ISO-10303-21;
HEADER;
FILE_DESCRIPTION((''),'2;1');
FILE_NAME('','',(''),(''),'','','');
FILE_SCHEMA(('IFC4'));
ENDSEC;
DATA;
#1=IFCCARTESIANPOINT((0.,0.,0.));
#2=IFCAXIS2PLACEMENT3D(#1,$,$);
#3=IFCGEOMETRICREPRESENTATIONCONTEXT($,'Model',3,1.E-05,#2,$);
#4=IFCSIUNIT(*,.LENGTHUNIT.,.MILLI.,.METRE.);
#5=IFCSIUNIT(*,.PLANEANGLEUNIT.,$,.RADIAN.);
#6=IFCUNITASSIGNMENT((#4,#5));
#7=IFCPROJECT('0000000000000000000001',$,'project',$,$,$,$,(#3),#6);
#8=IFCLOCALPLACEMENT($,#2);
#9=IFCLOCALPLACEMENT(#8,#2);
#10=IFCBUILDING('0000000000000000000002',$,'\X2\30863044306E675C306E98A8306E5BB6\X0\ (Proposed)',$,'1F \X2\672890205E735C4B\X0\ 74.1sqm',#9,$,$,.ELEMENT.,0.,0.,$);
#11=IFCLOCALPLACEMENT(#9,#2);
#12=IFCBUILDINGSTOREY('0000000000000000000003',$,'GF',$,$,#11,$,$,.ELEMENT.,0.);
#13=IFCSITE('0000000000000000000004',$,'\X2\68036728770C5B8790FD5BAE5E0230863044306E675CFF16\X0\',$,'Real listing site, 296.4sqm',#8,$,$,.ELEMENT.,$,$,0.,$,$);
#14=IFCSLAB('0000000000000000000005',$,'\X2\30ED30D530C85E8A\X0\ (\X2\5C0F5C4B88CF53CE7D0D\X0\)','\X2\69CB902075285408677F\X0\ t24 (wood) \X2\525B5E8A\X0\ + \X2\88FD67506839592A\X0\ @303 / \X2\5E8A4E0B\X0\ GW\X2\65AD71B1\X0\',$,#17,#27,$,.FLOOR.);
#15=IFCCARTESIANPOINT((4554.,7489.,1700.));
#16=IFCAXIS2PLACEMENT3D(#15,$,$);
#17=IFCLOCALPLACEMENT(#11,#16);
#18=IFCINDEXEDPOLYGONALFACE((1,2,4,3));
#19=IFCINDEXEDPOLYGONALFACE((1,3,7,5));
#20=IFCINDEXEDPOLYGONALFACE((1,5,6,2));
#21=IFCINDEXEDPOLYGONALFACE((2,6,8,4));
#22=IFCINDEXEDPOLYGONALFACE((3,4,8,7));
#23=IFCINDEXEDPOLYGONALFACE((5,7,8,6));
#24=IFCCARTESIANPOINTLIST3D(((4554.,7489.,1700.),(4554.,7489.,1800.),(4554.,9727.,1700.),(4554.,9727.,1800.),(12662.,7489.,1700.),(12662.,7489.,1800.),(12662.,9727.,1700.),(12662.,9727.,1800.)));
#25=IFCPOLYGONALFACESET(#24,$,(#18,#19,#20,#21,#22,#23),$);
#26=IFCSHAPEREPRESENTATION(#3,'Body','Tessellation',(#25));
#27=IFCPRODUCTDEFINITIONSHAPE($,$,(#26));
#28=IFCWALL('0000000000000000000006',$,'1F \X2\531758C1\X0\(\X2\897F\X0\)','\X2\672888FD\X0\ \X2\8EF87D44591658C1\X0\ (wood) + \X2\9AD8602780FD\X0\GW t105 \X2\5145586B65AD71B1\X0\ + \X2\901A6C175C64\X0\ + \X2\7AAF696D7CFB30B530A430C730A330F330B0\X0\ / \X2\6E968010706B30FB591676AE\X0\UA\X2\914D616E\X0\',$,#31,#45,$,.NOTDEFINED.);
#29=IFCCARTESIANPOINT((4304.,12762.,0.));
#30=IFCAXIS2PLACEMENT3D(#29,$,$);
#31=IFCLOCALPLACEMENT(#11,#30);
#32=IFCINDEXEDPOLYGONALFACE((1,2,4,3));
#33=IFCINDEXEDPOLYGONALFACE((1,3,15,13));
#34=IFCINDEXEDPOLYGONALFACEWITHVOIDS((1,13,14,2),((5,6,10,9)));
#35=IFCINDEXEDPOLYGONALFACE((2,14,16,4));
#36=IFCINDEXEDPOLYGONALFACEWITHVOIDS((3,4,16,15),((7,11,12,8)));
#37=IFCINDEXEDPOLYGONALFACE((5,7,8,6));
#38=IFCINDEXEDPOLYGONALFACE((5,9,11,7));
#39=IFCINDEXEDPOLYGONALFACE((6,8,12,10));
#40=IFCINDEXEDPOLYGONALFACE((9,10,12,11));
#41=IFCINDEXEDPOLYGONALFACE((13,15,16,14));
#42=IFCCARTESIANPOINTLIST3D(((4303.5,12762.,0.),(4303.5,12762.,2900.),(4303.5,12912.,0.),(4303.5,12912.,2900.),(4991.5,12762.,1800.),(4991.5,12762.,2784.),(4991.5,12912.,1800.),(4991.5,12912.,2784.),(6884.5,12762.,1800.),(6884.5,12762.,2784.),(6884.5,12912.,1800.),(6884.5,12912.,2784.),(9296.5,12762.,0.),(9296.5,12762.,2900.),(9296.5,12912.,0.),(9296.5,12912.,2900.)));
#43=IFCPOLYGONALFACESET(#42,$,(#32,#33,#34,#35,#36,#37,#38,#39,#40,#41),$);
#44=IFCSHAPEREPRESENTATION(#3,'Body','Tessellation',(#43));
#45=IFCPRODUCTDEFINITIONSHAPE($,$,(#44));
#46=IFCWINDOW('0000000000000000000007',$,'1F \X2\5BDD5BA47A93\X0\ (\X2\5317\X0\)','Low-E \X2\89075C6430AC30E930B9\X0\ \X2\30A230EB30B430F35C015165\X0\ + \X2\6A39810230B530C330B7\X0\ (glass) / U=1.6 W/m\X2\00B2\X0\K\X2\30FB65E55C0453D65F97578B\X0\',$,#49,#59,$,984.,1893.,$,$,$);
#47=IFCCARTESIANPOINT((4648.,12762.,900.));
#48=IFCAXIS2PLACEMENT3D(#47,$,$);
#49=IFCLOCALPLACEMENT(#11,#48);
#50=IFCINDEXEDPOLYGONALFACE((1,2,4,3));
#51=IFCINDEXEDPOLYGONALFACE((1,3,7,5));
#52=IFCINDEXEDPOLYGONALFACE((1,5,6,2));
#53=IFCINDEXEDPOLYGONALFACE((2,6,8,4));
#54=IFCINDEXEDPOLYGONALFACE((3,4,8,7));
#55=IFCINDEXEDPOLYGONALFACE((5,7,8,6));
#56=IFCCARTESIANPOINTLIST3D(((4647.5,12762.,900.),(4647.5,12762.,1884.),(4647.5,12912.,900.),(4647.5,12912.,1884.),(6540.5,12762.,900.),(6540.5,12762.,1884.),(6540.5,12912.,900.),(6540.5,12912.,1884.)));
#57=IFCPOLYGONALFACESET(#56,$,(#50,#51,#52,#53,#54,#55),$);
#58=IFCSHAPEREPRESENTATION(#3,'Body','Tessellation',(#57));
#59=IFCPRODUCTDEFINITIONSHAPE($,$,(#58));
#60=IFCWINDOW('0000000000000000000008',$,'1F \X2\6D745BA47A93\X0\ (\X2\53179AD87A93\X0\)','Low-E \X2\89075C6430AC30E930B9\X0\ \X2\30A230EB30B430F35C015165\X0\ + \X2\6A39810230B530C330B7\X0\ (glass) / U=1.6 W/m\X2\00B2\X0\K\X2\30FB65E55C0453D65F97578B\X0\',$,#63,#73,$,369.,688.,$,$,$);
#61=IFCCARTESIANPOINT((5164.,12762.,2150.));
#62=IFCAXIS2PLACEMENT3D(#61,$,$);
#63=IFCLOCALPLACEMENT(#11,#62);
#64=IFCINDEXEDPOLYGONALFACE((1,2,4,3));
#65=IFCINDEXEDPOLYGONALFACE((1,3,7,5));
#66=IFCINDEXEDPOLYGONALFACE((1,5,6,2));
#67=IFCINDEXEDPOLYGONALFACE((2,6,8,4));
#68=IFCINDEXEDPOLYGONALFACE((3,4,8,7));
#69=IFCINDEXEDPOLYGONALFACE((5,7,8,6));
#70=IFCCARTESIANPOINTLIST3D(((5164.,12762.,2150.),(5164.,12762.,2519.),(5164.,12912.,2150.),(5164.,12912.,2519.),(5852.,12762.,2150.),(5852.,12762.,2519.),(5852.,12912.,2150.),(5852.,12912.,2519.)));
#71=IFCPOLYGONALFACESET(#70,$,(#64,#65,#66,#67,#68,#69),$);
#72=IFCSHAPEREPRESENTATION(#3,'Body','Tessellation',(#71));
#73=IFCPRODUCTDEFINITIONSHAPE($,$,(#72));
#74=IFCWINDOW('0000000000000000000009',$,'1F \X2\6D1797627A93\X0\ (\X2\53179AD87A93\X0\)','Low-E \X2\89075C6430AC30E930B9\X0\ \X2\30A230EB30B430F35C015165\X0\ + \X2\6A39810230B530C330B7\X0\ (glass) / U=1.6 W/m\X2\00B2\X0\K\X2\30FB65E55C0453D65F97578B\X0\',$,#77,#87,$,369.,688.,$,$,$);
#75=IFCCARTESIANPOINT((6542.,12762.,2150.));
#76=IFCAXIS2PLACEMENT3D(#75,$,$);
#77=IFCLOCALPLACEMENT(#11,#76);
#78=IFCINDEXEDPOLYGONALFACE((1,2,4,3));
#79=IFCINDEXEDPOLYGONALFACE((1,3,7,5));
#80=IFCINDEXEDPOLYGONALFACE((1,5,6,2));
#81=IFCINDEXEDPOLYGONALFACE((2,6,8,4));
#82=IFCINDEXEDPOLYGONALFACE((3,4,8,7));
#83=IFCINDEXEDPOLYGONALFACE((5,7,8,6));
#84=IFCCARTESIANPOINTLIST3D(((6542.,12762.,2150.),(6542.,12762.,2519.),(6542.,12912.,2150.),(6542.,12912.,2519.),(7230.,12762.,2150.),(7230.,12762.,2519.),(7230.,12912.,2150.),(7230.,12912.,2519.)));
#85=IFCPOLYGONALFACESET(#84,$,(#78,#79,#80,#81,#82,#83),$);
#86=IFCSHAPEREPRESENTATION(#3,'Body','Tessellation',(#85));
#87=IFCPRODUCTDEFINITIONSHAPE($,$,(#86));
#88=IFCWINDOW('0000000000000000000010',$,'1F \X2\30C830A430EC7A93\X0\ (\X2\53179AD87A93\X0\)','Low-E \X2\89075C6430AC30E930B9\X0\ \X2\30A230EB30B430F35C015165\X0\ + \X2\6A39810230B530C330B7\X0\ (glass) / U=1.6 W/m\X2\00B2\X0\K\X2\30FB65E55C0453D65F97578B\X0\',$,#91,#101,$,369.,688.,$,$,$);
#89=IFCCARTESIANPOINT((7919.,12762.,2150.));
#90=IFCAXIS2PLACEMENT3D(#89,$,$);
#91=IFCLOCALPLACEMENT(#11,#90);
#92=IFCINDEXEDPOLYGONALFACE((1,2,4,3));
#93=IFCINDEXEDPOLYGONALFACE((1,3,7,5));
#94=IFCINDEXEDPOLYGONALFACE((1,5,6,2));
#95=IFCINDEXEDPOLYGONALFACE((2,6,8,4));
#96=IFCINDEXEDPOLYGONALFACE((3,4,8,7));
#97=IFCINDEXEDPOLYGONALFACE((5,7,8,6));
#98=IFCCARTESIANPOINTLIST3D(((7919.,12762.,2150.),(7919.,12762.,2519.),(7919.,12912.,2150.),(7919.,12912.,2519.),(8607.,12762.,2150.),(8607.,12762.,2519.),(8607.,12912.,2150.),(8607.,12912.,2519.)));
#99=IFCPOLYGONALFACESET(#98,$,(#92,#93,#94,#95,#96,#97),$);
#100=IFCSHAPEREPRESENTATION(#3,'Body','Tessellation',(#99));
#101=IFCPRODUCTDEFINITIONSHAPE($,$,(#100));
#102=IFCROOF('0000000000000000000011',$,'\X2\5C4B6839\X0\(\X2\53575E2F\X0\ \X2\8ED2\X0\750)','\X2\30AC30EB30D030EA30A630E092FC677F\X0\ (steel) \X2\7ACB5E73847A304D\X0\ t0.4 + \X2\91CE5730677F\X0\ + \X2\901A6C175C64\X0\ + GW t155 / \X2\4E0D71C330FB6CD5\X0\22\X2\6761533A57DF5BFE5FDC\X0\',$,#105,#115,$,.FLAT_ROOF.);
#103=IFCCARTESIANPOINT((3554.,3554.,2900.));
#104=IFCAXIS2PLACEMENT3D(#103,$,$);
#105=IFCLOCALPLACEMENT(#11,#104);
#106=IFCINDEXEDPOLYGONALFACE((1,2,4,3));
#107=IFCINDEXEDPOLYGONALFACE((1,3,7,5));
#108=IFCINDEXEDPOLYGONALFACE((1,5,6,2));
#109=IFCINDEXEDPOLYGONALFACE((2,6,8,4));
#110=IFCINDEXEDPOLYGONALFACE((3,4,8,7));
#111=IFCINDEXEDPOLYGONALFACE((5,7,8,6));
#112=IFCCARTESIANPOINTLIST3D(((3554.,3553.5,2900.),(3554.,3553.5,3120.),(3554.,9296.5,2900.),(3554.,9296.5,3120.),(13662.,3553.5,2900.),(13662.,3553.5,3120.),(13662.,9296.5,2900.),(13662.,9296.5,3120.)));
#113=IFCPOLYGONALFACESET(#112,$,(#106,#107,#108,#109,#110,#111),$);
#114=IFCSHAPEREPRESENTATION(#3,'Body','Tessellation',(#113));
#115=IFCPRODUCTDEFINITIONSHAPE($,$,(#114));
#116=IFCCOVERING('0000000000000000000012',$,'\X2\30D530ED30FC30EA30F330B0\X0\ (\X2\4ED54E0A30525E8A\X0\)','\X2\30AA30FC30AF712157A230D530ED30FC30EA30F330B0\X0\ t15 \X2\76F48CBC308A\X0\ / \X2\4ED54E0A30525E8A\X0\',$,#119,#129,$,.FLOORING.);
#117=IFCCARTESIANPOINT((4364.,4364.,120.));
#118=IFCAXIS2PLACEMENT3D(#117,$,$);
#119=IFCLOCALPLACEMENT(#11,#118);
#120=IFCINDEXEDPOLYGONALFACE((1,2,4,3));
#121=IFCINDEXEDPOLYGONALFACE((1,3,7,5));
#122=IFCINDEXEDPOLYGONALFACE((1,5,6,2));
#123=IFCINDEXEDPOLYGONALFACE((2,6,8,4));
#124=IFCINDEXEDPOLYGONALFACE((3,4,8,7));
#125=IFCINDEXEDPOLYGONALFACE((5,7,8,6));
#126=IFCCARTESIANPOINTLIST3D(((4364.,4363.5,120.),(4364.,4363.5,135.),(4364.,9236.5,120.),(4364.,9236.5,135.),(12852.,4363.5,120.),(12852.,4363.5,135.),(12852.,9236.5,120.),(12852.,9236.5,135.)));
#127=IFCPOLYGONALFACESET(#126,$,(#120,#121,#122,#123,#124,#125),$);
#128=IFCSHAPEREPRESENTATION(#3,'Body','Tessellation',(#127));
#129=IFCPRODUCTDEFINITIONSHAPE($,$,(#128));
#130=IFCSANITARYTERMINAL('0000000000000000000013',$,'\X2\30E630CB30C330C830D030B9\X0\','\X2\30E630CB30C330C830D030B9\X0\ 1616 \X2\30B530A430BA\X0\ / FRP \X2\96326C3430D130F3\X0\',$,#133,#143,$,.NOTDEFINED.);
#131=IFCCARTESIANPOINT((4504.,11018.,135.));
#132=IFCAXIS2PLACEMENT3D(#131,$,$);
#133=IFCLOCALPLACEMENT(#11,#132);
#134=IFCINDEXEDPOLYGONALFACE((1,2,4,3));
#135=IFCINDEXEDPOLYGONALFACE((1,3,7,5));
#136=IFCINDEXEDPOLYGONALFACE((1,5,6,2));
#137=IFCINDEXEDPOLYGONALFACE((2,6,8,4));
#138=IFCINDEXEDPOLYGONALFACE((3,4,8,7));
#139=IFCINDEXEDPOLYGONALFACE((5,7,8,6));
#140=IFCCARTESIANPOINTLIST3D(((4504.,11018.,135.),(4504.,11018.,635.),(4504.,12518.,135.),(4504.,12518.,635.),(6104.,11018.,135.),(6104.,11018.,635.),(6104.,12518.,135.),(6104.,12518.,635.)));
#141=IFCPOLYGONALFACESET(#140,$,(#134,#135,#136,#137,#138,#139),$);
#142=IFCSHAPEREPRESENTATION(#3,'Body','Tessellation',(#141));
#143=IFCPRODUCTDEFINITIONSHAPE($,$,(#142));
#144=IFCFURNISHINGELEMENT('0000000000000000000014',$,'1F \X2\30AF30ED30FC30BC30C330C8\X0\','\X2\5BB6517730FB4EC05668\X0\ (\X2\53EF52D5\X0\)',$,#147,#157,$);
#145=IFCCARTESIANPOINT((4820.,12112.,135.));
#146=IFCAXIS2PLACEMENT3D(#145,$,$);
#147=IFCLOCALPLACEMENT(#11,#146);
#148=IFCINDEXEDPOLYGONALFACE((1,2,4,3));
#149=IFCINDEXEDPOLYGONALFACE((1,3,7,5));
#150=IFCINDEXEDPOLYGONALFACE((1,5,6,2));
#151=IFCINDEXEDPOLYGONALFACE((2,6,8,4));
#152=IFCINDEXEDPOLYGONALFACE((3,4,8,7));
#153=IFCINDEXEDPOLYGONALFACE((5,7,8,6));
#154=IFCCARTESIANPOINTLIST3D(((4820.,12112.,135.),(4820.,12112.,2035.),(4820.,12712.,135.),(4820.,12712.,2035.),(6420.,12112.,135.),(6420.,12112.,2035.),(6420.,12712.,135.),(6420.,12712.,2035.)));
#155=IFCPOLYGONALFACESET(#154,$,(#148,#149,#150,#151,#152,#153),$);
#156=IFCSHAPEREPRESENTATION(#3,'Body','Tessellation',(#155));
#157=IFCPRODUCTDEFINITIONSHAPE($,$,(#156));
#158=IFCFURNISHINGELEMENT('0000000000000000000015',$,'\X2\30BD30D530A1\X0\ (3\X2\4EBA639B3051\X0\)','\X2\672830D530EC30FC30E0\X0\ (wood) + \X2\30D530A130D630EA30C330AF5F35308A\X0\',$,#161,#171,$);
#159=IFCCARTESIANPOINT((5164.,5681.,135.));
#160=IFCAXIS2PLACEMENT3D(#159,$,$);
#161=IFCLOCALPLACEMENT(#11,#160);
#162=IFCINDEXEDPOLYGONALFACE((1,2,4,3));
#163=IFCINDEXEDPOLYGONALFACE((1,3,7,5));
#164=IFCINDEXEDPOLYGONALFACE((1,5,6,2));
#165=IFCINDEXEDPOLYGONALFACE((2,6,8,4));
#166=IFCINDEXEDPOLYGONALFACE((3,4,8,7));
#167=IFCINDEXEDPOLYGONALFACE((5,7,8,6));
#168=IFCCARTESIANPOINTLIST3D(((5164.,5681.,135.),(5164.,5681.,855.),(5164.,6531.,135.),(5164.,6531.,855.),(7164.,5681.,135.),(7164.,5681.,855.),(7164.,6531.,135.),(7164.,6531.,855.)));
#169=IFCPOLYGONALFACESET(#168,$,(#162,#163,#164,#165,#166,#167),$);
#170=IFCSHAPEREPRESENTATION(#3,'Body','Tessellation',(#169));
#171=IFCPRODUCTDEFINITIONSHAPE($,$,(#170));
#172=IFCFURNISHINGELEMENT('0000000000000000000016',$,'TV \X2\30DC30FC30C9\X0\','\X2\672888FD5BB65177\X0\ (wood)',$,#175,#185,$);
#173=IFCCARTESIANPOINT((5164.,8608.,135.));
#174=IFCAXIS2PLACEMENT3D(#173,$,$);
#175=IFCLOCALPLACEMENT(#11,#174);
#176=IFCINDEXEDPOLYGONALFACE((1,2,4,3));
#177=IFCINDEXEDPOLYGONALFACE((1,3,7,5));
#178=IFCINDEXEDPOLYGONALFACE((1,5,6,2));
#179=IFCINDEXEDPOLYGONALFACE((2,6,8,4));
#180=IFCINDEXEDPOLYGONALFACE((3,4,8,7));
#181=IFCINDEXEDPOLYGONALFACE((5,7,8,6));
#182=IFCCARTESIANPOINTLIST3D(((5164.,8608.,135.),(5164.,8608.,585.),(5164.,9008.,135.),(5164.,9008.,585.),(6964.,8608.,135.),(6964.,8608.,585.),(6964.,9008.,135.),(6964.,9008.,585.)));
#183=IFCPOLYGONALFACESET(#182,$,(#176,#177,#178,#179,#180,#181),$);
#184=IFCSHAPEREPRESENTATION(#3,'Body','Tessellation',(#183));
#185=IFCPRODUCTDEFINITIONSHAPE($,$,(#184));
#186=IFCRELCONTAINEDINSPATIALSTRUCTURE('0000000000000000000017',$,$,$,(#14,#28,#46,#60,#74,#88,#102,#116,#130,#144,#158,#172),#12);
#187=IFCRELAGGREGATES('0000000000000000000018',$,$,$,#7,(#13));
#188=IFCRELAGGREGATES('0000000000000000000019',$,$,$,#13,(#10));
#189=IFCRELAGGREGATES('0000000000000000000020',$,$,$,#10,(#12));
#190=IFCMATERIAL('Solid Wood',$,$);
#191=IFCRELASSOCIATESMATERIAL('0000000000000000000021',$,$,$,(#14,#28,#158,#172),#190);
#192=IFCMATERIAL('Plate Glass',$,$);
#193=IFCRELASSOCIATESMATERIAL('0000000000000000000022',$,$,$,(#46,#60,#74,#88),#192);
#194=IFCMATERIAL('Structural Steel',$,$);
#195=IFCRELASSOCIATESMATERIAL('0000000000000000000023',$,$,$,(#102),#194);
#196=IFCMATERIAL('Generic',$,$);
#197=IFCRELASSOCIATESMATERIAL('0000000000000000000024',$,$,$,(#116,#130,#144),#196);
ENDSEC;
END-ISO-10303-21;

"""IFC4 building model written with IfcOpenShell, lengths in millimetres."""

from ifc_helpers import new_model, si_unit, frame, frame_2d, origin, place, context, project, spatial, rectangle, extrude, material, element, fill, save


model = new_model("IFC4")

# Units and contexts
model_context = context("Model", 3, precision=1e-05, world=origin())
ifc_project = project(units=[si_unit("LENGTHUNIT", "METRE", prefix="MILLI"), si_unit("PLANEANGLEUNIT", "RADIAN")], contexts=[model_context])

# Site, building, storey
site_placement = place(None, origin())
site = spatial("IfcSite", under=ifc_project, at=site_placement, Name="栃木県宇都宮市ゆいの杜６", ObjectType="Real listing site, 296.4sqm", CompositionType="ELEMENT", RefElevation=0.0)
building_placement = place(site_placement, origin())
building = spatial("IfcBuilding", under=site, at=building_placement, Name="ゆいの杜の風の家 (Proposed)", ObjectType="1F 木造平屋 74.1sqm", CompositionType="ELEMENT", ElevationOfRefHeight=0.0, ElevationOfTerrain=0.0)
storey_placement = place(building_placement, origin())
storey = spatial("IfcBuildingStorey", under=building, at=storey_placement, Name="GF", CompositionType="ELEMENT", Elevation=0.0)

# Slab
ifc_material_1 = material(Name="Solid Wood")
slab_1_placement = place(storey_placement, frame((4554.0, 7489.0, 1700.0)))
element("IfcSlab", 1, at=slab_1_placement, inside=storey, material=ifc_material_1, Name="ロフト床 (小屋裏収納)", Description="構造用合板 t24 (wood) 剛床 + 製材根太 @303 / 床下 GW断熱", PredefinedType="FLOOR", context=model_context, shape_type="SweptSolid", body=[
    extrude(rectangle(XDim=8108.0, YDim=2238.0, at=frame_2d((4054.0, 1119.0))), frame((4554.0, 7489.0, 1700.0)), (0.0, 0.0, 1.0), 100.0),
])

# Shared definitions
ifc_material_2 = material(Name="Plate Glass")

# Wall, openings, windows
wall_1_placement = place(storey_placement, frame((4304.0, 12762.0, 0.0)))
wall_1 = element("IfcWall", 2, at=wall_1_placement, inside=storey, material=ifc_material_1, Name="1F 北壁(西)", Description="木製 軸組外壁 (wood) + 高性能GW t105 充填断熱 + 通気層 + 窯業系サイディング / 準耐火・外皮UA配慮", PredefinedType="NOTDEFINED", context=model_context, shape_type="SweptSolid", body=[
    extrude(rectangle(XDim=4993.0, YDim=150.0, at=frame_2d((2496.0, 75.0))), frame((4304.0, 12762.0, 0.0)), (0.0, 0.0, 1.0), 2900.0),
])
opening_1_placement = place(storey_placement, frame((4648.0, 12762.0, 900.0)))
opening_1 = element("IfcOpeningElement", 3, at=opening_1_placement, cuts=wall_1, PredefinedType="NOTDEFINED", context=model_context, shape_type="SweptSolid", body=[
    extrude(rectangle(XDim=1893.0, YDim=150.0, at=frame_2d((946.0, 75.0))), frame((4648.0, 12762.0, 900.0)), (0.0, 0.0, 1.0), 984.0),
])
opening_2_placement = place(storey_placement, frame((5164.0, 12762.0, 2150.0)))
opening_2 = element("IfcOpeningElement", 4, at=opening_2_placement, cuts=wall_1, PredefinedType="NOTDEFINED", context=model_context, shape_type="SweptSolid", body=[
    extrude(rectangle(XDim=688.0, YDim=150.0, at=frame_2d((344.0, 75.0))), frame((5164.0, 12762.0, 2150.0)), (0.0, 0.0, 1.0), 369.0),
])
opening_3_placement = place(storey_placement, frame((6542.0, 12762.0, 2150.0)))
opening_3 = element("IfcOpeningElement", 5, at=opening_3_placement, cuts=wall_1, PredefinedType="NOTDEFINED", context=model_context, shape_type="SweptSolid", body=[
    extrude(rectangle(XDim=688.0, YDim=150.0, at=frame_2d((344.0, 75.0))), frame((6542.0, 12762.0, 2150.0)), (0.0, 0.0, 1.0), 369.0),
])
opening_4_placement = place(storey_placement, frame((7919.0, 12762.0, 2150.0)))
opening_4 = element("IfcOpeningElement", 6, at=opening_4_placement, cuts=wall_1, PredefinedType="NOTDEFINED", context=model_context, shape_type="SweptSolid", body=[
    extrude(rectangle(XDim=688.0, YDim=150.0, at=frame_2d((344.0, 75.0))), frame((7919.0, 12762.0, 2150.0)), (0.0, 0.0, 1.0), 369.0),
])
window_1_placement = place(storey_placement, frame((4648.0, 12762.0, 900.0)))
window_1 = element("IfcWindow", 7, at=window_1_placement, inside=storey, material=ifc_material_2, Name="1F 寝室窓 (北)", Description="Low-E 複層ガラス アルゴン封入 + 樹脂サッシ (glass) / U=1.6 W/m²K・日射取得型", OverallHeight=984.0, OverallWidth=1893.0, context=model_context, shape_type="SweptSolid", body=[
    extrude(rectangle(XDim=1893.0, YDim=150.0, at=frame_2d((946.0, 75.0))), frame((4648.0, 12762.0, 900.0)), (0.0, 0.0, 1.0), 984.0),
])
fill(opening_1, window_1)
window_2_placement = place(storey_placement, frame((5164.0, 12762.0, 2150.0)))
window_2 = element("IfcWindow", 8, at=window_2_placement, inside=storey, material=ifc_material_2, Name="1F 浴室窓 (北高窓)", Description="Low-E 複層ガラス アルゴン封入 + 樹脂サッシ (glass) / U=1.6 W/m²K・日射取得型", OverallHeight=369.0, OverallWidth=688.0, context=model_context, shape_type="SweptSolid", body=[
    extrude(rectangle(XDim=688.0, YDim=150.0, at=frame_2d((344.0, 75.0))), frame((5164.0, 12762.0, 2150.0)), (0.0, 0.0, 1.0), 369.0),
])
fill(opening_2, window_2)
window_3_placement = place(storey_placement, frame((6542.0, 12762.0, 2150.0)))
window_3 = element("IfcWindow", 9, at=window_3_placement, inside=storey, material=ifc_material_2, Name="1F 洗面窓 (北高窓)", Description="Low-E 複層ガラス アルゴン封入 + 樹脂サッシ (glass) / U=1.6 W/m²K・日射取得型", OverallHeight=369.0, OverallWidth=688.0, context=model_context, shape_type="SweptSolid", body=[
    extrude(rectangle(XDim=688.0, YDim=150.0, at=frame_2d((344.0, 75.0))), frame((6542.0, 12762.0, 2150.0)), (0.0, 0.0, 1.0), 369.0),
])
fill(opening_3, window_3)
window_4_placement = place(storey_placement, frame((7919.0, 12762.0, 2150.0)))
window_4 = element("IfcWindow", 10, at=window_4_placement, inside=storey, material=ifc_material_2, Name="1F トイレ窓 (北高窓)", Description="Low-E 複層ガラス アルゴン封入 + 樹脂サッシ (glass) / U=1.6 W/m²K・日射取得型", OverallHeight=369.0, OverallWidth=688.0, context=model_context, shape_type="SweptSolid", body=[
    extrude(rectangle(XDim=688.0, YDim=150.0, at=frame_2d((344.0, 75.0))), frame((7919.0, 12762.0, 2150.0)), (0.0, 0.0, 1.0), 369.0),
])
fill(opening_4, window_4)

# Roof
ifc_material_3 = material(Name="Structural Steel")
roof_1_placement = place(storey_placement, frame((3554.0, 3554.0, 2900.0)))
element("IfcRoof", 11, at=roof_1_placement, inside=storey, material=ifc_material_3, Name="屋根(南帯 軒750)", Description="ガルバリウム鋼板 (steel) 立平葺き t0.4 + 野地板 + 通気層 + GW t155 / 不燃・法22条区域対応", PredefinedType="FLAT_ROOF", context=model_context, shape_type="SweptSolid", body=[
    extrude(rectangle(XDim=10108.0, YDim=5743.0, at=frame_2d((5054.0, 2871.0))), frame((3554.0, 3554.0, 2900.0)), (0.0, 0.0, 1.0), 220.0),
])

# Covering
ifc_material_4 = material(Name="Generic")
covering_1_placement = place(storey_placement, frame((4364.0, 4364.0, 120.0)))
element("IfcCovering", 12, at=covering_1_placement, inside=storey, material=ifc_material_4, Name="フローリング (仕上げ床)", Description="オーク無垢フローリング t15 直貼り / 仕上げ床", PredefinedType="FLOORING", context=model_context, shape_type="SweptSolid", body=[
    extrude(rectangle(XDim=8488.0, YDim=4873.0, at=frame_2d((4244.0, 2436.0))), frame((4364.0, 4364.0, 120.0)), (0.0, 0.0, 1.0), 15.0),
])

# Sanitary terminal
sanitary_terminal_placement = place(storey_placement, frame((4504.0, 11018.0, 135.0)))
element("IfcSanitaryTerminal", 13, at=sanitary_terminal_placement, inside=storey, material=ifc_material_4, Name="ユニットバス", Description="ユニットバス 1616 サイズ / FRP 防水パン", PredefinedType="NOTDEFINED", context=model_context, shape_type="SweptSolid", body=[
    extrude(rectangle(XDim=1600.0, YDim=1500.0, at=frame_2d((800.0, 750.0))), frame((4504.0, 11018.0, 135.0)), (0.0, 0.0, 1.0), 500.0),
])

# Furnishing elements
furnishing_1_placement = place(storey_placement, frame((4820.0, 12112.0, 135.0)))
element("IfcFurnishingElement", 14, at=furnishing_1_placement, inside=storey, material=ifc_material_4, Name="1F クローゼット", Description="家具・什器 (可動)", context=model_context, shape_type="SweptSolid", body=[
    extrude(rectangle(XDim=1600.0, YDim=600.0, at=frame_2d((800.0, 300.0))), frame((4820.0, 12112.0, 135.0)), (0.0, 0.0, 1.0), 1900.0),
])
furnishing_2_placement = place(storey_placement, frame((5164.0, 5681.0, 135.0)))
element("IfcFurnishingElement", 15, at=furnishing_2_placement, inside=storey, material=ifc_material_1, Name="ソファ (3人掛け)", Description="木フレーム (wood) + ファブリック張り", context=model_context, shape_type="SweptSolid", body=[
    extrude(rectangle(XDim=2000.0, YDim=850.0, at=frame_2d((1000.0, 425.0))), frame((5164.0, 5681.0, 135.0)), (0.0, 0.0, 1.0), 720.0),
])
furnishing_3_placement = place(storey_placement, frame((5164.0, 8608.0, 135.0)))
element("IfcFurnishingElement", 16, at=furnishing_3_placement, inside=storey, material=ifc_material_1, Name="TV ボード", Description="木製家具 (wood)", context=model_context, shape_type="SweptSolid", body=[
    extrude(rectangle(XDim=1800.0, YDim=400.0, at=frame_2d((900.0, 200.0))), frame((5164.0, 8608.0, 135.0)), (0.0, 0.0, 1.0), 450.0),
])

save(model, "model.ifc")
